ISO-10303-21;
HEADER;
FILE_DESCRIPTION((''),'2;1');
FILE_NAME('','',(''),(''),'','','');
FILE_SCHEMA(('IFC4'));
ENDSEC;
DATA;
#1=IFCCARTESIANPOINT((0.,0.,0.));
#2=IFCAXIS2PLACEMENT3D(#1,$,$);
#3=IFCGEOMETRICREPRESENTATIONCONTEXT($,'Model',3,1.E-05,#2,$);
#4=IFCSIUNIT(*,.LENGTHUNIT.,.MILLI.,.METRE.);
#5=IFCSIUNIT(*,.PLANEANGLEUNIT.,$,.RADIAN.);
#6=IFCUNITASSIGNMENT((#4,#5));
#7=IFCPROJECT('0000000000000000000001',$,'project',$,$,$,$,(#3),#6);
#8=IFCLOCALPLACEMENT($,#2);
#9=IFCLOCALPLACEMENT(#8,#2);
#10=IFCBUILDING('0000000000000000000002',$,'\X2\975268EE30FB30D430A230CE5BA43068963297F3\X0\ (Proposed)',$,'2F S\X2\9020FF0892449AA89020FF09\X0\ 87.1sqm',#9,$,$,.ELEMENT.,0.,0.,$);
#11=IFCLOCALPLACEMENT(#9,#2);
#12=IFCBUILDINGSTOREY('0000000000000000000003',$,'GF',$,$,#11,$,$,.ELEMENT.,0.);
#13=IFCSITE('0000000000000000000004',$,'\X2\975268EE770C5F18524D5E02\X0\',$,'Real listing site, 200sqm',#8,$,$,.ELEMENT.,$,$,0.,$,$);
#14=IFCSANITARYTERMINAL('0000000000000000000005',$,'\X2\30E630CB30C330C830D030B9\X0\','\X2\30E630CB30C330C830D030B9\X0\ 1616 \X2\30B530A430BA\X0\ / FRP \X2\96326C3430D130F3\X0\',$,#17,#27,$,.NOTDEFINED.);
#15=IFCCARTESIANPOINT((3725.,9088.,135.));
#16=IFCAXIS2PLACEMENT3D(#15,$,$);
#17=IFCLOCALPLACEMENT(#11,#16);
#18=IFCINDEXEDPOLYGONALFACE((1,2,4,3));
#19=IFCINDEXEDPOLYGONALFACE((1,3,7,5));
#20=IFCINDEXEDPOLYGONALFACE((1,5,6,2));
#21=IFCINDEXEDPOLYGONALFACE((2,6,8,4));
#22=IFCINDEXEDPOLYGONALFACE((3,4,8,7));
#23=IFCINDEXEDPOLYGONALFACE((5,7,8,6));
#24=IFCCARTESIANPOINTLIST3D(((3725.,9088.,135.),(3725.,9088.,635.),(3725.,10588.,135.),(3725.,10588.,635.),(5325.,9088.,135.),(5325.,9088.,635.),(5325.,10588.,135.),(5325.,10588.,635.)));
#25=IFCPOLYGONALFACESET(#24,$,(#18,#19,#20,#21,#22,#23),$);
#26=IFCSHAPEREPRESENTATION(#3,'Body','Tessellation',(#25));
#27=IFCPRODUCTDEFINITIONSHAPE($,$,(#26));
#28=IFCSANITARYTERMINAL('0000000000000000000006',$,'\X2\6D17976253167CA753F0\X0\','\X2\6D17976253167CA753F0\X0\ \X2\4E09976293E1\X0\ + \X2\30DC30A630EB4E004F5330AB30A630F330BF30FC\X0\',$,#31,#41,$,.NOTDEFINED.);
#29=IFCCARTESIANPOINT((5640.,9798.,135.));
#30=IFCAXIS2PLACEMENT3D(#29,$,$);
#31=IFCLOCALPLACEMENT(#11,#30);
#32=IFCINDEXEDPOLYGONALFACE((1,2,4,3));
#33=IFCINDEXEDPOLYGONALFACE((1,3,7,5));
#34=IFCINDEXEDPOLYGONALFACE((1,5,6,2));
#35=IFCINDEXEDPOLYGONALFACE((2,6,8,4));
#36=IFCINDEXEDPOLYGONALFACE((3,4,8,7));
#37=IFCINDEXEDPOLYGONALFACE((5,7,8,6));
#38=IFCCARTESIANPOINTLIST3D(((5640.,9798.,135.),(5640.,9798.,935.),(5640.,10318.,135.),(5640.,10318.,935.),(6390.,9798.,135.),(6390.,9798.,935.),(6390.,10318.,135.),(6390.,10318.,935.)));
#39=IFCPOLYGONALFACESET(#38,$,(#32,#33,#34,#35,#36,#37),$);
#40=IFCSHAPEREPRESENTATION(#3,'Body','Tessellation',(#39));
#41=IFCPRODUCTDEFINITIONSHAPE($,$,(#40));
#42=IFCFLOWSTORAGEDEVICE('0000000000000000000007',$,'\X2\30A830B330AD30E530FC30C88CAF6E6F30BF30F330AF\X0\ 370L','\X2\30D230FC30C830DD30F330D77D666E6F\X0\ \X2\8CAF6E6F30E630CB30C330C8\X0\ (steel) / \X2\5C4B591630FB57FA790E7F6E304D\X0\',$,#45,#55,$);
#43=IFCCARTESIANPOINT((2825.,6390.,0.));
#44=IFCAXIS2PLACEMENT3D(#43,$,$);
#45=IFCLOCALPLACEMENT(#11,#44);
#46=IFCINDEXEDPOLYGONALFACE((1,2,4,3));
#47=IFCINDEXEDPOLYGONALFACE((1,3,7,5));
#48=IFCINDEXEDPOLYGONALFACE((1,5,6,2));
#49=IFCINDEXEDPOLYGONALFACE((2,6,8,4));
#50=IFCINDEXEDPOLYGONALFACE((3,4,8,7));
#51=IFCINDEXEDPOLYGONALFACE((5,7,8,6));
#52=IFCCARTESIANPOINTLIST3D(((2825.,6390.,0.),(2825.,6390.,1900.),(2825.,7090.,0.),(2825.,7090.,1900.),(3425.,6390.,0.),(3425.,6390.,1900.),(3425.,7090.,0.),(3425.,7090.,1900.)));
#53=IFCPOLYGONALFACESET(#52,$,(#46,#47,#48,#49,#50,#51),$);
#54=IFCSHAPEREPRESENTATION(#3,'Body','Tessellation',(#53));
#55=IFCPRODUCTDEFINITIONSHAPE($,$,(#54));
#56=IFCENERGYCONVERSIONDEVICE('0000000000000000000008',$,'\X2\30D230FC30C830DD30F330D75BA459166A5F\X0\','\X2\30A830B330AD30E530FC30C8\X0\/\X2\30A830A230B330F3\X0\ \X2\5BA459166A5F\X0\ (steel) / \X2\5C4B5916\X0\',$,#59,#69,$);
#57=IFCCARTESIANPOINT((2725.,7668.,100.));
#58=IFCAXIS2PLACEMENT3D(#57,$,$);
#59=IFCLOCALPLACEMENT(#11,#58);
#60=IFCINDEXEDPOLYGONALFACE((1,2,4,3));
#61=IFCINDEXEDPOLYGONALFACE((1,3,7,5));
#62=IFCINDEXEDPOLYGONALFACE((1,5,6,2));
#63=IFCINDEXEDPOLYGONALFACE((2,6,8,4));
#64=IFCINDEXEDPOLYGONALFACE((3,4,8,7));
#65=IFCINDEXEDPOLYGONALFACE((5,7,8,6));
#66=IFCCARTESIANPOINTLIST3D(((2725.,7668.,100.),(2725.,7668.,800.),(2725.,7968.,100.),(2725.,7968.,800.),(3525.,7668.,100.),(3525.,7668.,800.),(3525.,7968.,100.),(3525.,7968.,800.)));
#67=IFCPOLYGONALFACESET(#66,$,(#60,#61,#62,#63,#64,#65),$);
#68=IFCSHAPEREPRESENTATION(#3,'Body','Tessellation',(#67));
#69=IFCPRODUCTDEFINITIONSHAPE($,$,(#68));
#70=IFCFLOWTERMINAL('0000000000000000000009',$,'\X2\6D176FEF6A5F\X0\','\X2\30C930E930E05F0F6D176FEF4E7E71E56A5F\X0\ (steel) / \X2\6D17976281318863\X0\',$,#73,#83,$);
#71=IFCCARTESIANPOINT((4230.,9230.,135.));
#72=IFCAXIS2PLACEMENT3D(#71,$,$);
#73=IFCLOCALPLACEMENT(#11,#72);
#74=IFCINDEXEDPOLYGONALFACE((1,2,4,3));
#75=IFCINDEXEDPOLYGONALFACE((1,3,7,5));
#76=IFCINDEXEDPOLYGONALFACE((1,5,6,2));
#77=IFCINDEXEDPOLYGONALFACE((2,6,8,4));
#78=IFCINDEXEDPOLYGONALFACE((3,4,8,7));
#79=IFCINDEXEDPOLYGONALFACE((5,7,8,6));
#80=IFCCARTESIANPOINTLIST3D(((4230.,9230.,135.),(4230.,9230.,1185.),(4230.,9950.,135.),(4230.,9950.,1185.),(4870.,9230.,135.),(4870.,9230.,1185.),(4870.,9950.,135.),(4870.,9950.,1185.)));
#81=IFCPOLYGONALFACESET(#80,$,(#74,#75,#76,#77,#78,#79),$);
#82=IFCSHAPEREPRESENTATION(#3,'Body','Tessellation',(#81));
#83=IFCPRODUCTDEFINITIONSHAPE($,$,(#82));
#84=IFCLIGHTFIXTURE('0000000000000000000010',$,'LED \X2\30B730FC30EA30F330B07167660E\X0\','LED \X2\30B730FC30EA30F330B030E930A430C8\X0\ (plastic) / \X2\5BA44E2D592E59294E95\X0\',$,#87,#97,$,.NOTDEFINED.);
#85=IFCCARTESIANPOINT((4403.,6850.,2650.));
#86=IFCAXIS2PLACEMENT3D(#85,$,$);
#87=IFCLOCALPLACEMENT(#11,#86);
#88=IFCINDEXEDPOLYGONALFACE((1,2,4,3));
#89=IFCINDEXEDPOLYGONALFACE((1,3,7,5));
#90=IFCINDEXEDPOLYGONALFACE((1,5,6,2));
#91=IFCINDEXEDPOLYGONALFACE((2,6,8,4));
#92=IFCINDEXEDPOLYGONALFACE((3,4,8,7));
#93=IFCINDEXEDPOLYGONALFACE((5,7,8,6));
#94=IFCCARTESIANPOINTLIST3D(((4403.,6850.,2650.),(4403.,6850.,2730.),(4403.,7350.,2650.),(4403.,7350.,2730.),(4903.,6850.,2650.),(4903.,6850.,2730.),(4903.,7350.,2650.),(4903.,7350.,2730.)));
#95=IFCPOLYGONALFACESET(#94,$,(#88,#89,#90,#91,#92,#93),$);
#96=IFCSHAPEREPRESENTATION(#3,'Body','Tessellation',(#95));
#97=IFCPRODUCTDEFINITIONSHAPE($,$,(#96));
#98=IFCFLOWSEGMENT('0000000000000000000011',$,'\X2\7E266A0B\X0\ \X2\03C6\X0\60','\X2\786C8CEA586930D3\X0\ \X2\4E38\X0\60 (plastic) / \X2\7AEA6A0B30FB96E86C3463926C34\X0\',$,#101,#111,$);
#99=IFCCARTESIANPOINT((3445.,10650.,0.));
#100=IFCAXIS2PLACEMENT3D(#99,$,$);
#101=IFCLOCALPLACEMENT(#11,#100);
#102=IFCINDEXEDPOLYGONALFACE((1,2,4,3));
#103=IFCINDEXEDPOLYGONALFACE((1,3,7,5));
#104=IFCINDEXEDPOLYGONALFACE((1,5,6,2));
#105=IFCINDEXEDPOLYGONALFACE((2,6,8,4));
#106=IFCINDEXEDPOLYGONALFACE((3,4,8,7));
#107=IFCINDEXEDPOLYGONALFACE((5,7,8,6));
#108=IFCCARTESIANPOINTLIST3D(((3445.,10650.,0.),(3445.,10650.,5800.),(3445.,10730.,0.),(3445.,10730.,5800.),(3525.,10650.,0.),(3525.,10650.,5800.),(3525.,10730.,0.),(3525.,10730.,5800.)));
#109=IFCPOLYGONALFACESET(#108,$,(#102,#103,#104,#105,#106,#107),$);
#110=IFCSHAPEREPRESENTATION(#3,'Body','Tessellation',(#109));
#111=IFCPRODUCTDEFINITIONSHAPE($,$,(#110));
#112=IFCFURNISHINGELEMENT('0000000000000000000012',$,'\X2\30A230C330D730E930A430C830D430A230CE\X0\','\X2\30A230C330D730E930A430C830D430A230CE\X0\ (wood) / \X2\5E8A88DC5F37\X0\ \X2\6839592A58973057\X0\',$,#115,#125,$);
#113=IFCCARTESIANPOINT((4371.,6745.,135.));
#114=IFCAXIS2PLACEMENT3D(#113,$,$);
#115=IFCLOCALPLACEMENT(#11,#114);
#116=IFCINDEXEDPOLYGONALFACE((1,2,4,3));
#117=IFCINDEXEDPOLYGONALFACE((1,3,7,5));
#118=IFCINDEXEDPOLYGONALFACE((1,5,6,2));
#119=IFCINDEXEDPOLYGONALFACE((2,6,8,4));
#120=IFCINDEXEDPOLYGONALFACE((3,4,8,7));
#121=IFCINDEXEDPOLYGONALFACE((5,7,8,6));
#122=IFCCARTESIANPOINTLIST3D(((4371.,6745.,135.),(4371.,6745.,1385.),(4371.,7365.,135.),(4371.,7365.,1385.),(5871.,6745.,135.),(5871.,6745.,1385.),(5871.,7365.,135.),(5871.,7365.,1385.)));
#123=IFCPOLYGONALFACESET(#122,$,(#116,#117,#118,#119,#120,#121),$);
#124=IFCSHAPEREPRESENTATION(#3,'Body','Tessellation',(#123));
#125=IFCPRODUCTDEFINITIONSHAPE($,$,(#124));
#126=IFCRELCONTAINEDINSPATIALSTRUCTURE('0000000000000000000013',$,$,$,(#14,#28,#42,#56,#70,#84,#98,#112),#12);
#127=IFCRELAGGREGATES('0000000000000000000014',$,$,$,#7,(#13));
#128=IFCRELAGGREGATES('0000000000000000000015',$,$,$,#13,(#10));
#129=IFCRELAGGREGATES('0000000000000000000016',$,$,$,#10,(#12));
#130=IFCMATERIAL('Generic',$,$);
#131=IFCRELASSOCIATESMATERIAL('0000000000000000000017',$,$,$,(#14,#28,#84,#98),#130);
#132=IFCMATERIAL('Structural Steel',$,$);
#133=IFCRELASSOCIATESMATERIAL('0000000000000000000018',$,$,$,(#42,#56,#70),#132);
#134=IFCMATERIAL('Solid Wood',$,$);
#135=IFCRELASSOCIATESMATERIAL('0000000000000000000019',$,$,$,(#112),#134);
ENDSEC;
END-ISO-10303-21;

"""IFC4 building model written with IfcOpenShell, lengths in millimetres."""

from ifc_helpers import new_model, si_unit, frame, frame_2d, origin, place, context, project, spatial, rectangle, extrude, material, element, save


model = new_model("IFC4")

# Units and contexts
model_context = context("Model", 3, precision=1e-05, world=origin())
ifc_project = project(units=[si_unit("LENGTHUNIT", "METRE", prefix="MILLI"), si_unit("PLANEANGLEUNIT", "RADIAN")], contexts=[model_context])

# Site, building, storey
site_placement = place(None, origin())
site = spatial("IfcSite", under=ifc_project, at=site_placement, Name="青森県弘前市", ObjectType="Real listing site, 200sqm", CompositionType="ELEMENT", RefElevation=0.0)
building_placement = place(site_placement, origin())
building = spatial("IfcBuilding", under=site, at=building_placement, Name="青森・ピアノ室と防音 (Proposed)", ObjectType="2F S造（鉄骨造） 87.1sqm", CompositionType="ELEMENT", ElevationOfRefHeight=0.0, ElevationOfTerrain=0.0)
storey_placement = place(building_placement, origin())
storey = spatial("IfcBuildingStorey", under=building, at=storey_placement, Name="GF", CompositionType="ELEMENT", Elevation=0.0)

# Shared definitions
ifc_material_1 = material(Name="Solid Wood")

# Shared definitions
ifc_material_2 = material(Name="Generic")

# Sanitary terminals
sanitary_terminal_1_placement = place(storey_placement, frame((3725.0, 9088.0, 135.0)))
element("IfcSanitaryTerminal", 1, at=sanitary_terminal_1_placement, inside=storey, material=ifc_material_2, Name="ユニットバス", Description="ユニットバス 1616 サイズ / FRP 防水パン", PredefinedType="NOTDEFINED", context=model_context, shape_type="SweptSolid", body=[
    extrude(rectangle(XDim=1600.0, YDim=1500.0, at=frame_2d((800.0, 750.0))), frame((3725.0, 9088.0, 135.0)), (0.0, 0.0, 1.0), 500.0),
])
sanitary_terminal_2_placement = place(storey_placement, frame((5640.0, 9798.0, 135.0)))
element("IfcSanitaryTerminal", 2, at=sanitary_terminal_2_placement, inside=storey, material=ifc_material_2, Name="洗面化粧台", Description="洗面化粧台 三面鏡 + ボウル一体カウンター", PredefinedType="NOTDEFINED", context=model_context, shape_type="SweptSolid", body=[
    extrude(rectangle(XDim=750.0, YDim=520.0, at=frame_2d((375.0, 260.0))), frame((5640.0, 9798.0, 135.0)), (0.0, 0.0, 1.0), 800.0),
])

# Flow storage device
ifc_material_3 = material(Name="Structural Steel")
flow_storage_device_placement = place(storey_placement, frame((2825.0, 6390.0, 0.0)))
element("IfcFlowStorageDevice", 3, at=flow_storage_device_placement, inside=storey, material=ifc_material_3, Name="エコキュート貯湯タンク 370L", Description="ヒートポンプ給湯 貯湯ユニット (steel) / 屋外・基礎置き", context=model_context, shape_type="SweptSolid", body=[
    extrude(rectangle(XDim=600.0, YDim=700.0, at=frame_2d((300.0, 350.0))), frame((2825.0, 6390.0, 0.0)), (0.0, 0.0, 1.0), 1900.0),
])

# Energy conversion device
energy_conversion_device_placement = place(storey_placement, frame((2725.0, 7668.0, 100.0)))
element("IfcEnergyConversionDevice", 4, at=energy_conversion_device_placement, inside=storey, material=ifc_material_3, Name="ヒートポンプ室外機", Description="エコキュート/エアコン 室外機 (steel) / 屋外", context=model_context, shape_type="SweptSolid", body=[
    extrude(rectangle(XDim=800.0, YDim=300.0, at=frame_2d((400.0, 150.0))), frame((2725.0, 7668.0, 100.0)), (0.0, 0.0, 1.0), 700.0),
])

# Flow terminal
flow_terminal_placement = place(storey_placement, frame((4230.0, 9230.0, 135.0)))
element("IfcFlowTerminal", 5, at=flow_terminal_placement, inside=storey, material=ifc_material_3, Name="洗濯機", Description="ドラム式洗濯乾燥機 (steel) / 洗面脱衣", context=model_context, shape_type="SweptSolid", body=[
    extrude(rectangle(XDim=640.0, YDim=720.0, at=frame_2d((320.0, 360.0))), frame((4230.0, 9230.0, 135.0)), (0.0, 0.0, 1.0), 1050.0),
])

# Light fixture
light_fixture_placement = place(storey_placement, frame((4403.0, 6850.0, 2650.0)))
element("IfcLightFixture", 6, at=light_fixture_placement, inside=storey, material=ifc_material_2, Name="LED シーリング照明", Description="LED シーリングライト (plastic) / 室中央天井", PredefinedType="NOTDEFINED", context=model_context, shape_type="SweptSolid", body=[
    extrude(rectangle(XDim=500.0, YDim=500.0, at=frame_2d((250.0, 250.0))), frame((4403.0, 6850.0, 2650.0)), (0.0, 0.0, 1.0), 80.0),
])

# Flow segment
flow_segment_placement = place(storey_placement, frame((3445.0, 10650.0, 0.0)))
element("IfcFlowSegment", 7, at=flow_segment_placement, inside=storey, material=ifc_material_2, Name="縦樋 φ60", Description="硬質塩ビ 丸60 (plastic) / 竪樋・雨水排水", context=model_context, shape_type="SweptSolid", body=[
    extrude(rectangle(XDim=80.0, YDim=80.0, at=frame_2d((40.0, 40.0))), frame((3445.0, 10650.0, 0.0)), (0.0, 0.0, 1.0), 5800.0),
])

# Furnishing element
furnishing_placement = place(storey_placement, frame((4371.0, 6745.0, 135.0)))
element("IfcFurnishingElement", 8, at=furnishing_placement, inside=storey, material=ifc_material_1, Name="アップライトピアノ", Description="アップライトピアノ (wood) / 床補強 根太増し", context=model_context, shape_type="SweptSolid", body=[
    extrude(rectangle(XDim=1500.0, YDim=620.0, at=frame_2d((750.0, 310.0))), frame((4371.0, 6745.0, 135.0)), (0.0, 0.0, 1.0), 1250.0),
])

save(model, "model.ifc")
